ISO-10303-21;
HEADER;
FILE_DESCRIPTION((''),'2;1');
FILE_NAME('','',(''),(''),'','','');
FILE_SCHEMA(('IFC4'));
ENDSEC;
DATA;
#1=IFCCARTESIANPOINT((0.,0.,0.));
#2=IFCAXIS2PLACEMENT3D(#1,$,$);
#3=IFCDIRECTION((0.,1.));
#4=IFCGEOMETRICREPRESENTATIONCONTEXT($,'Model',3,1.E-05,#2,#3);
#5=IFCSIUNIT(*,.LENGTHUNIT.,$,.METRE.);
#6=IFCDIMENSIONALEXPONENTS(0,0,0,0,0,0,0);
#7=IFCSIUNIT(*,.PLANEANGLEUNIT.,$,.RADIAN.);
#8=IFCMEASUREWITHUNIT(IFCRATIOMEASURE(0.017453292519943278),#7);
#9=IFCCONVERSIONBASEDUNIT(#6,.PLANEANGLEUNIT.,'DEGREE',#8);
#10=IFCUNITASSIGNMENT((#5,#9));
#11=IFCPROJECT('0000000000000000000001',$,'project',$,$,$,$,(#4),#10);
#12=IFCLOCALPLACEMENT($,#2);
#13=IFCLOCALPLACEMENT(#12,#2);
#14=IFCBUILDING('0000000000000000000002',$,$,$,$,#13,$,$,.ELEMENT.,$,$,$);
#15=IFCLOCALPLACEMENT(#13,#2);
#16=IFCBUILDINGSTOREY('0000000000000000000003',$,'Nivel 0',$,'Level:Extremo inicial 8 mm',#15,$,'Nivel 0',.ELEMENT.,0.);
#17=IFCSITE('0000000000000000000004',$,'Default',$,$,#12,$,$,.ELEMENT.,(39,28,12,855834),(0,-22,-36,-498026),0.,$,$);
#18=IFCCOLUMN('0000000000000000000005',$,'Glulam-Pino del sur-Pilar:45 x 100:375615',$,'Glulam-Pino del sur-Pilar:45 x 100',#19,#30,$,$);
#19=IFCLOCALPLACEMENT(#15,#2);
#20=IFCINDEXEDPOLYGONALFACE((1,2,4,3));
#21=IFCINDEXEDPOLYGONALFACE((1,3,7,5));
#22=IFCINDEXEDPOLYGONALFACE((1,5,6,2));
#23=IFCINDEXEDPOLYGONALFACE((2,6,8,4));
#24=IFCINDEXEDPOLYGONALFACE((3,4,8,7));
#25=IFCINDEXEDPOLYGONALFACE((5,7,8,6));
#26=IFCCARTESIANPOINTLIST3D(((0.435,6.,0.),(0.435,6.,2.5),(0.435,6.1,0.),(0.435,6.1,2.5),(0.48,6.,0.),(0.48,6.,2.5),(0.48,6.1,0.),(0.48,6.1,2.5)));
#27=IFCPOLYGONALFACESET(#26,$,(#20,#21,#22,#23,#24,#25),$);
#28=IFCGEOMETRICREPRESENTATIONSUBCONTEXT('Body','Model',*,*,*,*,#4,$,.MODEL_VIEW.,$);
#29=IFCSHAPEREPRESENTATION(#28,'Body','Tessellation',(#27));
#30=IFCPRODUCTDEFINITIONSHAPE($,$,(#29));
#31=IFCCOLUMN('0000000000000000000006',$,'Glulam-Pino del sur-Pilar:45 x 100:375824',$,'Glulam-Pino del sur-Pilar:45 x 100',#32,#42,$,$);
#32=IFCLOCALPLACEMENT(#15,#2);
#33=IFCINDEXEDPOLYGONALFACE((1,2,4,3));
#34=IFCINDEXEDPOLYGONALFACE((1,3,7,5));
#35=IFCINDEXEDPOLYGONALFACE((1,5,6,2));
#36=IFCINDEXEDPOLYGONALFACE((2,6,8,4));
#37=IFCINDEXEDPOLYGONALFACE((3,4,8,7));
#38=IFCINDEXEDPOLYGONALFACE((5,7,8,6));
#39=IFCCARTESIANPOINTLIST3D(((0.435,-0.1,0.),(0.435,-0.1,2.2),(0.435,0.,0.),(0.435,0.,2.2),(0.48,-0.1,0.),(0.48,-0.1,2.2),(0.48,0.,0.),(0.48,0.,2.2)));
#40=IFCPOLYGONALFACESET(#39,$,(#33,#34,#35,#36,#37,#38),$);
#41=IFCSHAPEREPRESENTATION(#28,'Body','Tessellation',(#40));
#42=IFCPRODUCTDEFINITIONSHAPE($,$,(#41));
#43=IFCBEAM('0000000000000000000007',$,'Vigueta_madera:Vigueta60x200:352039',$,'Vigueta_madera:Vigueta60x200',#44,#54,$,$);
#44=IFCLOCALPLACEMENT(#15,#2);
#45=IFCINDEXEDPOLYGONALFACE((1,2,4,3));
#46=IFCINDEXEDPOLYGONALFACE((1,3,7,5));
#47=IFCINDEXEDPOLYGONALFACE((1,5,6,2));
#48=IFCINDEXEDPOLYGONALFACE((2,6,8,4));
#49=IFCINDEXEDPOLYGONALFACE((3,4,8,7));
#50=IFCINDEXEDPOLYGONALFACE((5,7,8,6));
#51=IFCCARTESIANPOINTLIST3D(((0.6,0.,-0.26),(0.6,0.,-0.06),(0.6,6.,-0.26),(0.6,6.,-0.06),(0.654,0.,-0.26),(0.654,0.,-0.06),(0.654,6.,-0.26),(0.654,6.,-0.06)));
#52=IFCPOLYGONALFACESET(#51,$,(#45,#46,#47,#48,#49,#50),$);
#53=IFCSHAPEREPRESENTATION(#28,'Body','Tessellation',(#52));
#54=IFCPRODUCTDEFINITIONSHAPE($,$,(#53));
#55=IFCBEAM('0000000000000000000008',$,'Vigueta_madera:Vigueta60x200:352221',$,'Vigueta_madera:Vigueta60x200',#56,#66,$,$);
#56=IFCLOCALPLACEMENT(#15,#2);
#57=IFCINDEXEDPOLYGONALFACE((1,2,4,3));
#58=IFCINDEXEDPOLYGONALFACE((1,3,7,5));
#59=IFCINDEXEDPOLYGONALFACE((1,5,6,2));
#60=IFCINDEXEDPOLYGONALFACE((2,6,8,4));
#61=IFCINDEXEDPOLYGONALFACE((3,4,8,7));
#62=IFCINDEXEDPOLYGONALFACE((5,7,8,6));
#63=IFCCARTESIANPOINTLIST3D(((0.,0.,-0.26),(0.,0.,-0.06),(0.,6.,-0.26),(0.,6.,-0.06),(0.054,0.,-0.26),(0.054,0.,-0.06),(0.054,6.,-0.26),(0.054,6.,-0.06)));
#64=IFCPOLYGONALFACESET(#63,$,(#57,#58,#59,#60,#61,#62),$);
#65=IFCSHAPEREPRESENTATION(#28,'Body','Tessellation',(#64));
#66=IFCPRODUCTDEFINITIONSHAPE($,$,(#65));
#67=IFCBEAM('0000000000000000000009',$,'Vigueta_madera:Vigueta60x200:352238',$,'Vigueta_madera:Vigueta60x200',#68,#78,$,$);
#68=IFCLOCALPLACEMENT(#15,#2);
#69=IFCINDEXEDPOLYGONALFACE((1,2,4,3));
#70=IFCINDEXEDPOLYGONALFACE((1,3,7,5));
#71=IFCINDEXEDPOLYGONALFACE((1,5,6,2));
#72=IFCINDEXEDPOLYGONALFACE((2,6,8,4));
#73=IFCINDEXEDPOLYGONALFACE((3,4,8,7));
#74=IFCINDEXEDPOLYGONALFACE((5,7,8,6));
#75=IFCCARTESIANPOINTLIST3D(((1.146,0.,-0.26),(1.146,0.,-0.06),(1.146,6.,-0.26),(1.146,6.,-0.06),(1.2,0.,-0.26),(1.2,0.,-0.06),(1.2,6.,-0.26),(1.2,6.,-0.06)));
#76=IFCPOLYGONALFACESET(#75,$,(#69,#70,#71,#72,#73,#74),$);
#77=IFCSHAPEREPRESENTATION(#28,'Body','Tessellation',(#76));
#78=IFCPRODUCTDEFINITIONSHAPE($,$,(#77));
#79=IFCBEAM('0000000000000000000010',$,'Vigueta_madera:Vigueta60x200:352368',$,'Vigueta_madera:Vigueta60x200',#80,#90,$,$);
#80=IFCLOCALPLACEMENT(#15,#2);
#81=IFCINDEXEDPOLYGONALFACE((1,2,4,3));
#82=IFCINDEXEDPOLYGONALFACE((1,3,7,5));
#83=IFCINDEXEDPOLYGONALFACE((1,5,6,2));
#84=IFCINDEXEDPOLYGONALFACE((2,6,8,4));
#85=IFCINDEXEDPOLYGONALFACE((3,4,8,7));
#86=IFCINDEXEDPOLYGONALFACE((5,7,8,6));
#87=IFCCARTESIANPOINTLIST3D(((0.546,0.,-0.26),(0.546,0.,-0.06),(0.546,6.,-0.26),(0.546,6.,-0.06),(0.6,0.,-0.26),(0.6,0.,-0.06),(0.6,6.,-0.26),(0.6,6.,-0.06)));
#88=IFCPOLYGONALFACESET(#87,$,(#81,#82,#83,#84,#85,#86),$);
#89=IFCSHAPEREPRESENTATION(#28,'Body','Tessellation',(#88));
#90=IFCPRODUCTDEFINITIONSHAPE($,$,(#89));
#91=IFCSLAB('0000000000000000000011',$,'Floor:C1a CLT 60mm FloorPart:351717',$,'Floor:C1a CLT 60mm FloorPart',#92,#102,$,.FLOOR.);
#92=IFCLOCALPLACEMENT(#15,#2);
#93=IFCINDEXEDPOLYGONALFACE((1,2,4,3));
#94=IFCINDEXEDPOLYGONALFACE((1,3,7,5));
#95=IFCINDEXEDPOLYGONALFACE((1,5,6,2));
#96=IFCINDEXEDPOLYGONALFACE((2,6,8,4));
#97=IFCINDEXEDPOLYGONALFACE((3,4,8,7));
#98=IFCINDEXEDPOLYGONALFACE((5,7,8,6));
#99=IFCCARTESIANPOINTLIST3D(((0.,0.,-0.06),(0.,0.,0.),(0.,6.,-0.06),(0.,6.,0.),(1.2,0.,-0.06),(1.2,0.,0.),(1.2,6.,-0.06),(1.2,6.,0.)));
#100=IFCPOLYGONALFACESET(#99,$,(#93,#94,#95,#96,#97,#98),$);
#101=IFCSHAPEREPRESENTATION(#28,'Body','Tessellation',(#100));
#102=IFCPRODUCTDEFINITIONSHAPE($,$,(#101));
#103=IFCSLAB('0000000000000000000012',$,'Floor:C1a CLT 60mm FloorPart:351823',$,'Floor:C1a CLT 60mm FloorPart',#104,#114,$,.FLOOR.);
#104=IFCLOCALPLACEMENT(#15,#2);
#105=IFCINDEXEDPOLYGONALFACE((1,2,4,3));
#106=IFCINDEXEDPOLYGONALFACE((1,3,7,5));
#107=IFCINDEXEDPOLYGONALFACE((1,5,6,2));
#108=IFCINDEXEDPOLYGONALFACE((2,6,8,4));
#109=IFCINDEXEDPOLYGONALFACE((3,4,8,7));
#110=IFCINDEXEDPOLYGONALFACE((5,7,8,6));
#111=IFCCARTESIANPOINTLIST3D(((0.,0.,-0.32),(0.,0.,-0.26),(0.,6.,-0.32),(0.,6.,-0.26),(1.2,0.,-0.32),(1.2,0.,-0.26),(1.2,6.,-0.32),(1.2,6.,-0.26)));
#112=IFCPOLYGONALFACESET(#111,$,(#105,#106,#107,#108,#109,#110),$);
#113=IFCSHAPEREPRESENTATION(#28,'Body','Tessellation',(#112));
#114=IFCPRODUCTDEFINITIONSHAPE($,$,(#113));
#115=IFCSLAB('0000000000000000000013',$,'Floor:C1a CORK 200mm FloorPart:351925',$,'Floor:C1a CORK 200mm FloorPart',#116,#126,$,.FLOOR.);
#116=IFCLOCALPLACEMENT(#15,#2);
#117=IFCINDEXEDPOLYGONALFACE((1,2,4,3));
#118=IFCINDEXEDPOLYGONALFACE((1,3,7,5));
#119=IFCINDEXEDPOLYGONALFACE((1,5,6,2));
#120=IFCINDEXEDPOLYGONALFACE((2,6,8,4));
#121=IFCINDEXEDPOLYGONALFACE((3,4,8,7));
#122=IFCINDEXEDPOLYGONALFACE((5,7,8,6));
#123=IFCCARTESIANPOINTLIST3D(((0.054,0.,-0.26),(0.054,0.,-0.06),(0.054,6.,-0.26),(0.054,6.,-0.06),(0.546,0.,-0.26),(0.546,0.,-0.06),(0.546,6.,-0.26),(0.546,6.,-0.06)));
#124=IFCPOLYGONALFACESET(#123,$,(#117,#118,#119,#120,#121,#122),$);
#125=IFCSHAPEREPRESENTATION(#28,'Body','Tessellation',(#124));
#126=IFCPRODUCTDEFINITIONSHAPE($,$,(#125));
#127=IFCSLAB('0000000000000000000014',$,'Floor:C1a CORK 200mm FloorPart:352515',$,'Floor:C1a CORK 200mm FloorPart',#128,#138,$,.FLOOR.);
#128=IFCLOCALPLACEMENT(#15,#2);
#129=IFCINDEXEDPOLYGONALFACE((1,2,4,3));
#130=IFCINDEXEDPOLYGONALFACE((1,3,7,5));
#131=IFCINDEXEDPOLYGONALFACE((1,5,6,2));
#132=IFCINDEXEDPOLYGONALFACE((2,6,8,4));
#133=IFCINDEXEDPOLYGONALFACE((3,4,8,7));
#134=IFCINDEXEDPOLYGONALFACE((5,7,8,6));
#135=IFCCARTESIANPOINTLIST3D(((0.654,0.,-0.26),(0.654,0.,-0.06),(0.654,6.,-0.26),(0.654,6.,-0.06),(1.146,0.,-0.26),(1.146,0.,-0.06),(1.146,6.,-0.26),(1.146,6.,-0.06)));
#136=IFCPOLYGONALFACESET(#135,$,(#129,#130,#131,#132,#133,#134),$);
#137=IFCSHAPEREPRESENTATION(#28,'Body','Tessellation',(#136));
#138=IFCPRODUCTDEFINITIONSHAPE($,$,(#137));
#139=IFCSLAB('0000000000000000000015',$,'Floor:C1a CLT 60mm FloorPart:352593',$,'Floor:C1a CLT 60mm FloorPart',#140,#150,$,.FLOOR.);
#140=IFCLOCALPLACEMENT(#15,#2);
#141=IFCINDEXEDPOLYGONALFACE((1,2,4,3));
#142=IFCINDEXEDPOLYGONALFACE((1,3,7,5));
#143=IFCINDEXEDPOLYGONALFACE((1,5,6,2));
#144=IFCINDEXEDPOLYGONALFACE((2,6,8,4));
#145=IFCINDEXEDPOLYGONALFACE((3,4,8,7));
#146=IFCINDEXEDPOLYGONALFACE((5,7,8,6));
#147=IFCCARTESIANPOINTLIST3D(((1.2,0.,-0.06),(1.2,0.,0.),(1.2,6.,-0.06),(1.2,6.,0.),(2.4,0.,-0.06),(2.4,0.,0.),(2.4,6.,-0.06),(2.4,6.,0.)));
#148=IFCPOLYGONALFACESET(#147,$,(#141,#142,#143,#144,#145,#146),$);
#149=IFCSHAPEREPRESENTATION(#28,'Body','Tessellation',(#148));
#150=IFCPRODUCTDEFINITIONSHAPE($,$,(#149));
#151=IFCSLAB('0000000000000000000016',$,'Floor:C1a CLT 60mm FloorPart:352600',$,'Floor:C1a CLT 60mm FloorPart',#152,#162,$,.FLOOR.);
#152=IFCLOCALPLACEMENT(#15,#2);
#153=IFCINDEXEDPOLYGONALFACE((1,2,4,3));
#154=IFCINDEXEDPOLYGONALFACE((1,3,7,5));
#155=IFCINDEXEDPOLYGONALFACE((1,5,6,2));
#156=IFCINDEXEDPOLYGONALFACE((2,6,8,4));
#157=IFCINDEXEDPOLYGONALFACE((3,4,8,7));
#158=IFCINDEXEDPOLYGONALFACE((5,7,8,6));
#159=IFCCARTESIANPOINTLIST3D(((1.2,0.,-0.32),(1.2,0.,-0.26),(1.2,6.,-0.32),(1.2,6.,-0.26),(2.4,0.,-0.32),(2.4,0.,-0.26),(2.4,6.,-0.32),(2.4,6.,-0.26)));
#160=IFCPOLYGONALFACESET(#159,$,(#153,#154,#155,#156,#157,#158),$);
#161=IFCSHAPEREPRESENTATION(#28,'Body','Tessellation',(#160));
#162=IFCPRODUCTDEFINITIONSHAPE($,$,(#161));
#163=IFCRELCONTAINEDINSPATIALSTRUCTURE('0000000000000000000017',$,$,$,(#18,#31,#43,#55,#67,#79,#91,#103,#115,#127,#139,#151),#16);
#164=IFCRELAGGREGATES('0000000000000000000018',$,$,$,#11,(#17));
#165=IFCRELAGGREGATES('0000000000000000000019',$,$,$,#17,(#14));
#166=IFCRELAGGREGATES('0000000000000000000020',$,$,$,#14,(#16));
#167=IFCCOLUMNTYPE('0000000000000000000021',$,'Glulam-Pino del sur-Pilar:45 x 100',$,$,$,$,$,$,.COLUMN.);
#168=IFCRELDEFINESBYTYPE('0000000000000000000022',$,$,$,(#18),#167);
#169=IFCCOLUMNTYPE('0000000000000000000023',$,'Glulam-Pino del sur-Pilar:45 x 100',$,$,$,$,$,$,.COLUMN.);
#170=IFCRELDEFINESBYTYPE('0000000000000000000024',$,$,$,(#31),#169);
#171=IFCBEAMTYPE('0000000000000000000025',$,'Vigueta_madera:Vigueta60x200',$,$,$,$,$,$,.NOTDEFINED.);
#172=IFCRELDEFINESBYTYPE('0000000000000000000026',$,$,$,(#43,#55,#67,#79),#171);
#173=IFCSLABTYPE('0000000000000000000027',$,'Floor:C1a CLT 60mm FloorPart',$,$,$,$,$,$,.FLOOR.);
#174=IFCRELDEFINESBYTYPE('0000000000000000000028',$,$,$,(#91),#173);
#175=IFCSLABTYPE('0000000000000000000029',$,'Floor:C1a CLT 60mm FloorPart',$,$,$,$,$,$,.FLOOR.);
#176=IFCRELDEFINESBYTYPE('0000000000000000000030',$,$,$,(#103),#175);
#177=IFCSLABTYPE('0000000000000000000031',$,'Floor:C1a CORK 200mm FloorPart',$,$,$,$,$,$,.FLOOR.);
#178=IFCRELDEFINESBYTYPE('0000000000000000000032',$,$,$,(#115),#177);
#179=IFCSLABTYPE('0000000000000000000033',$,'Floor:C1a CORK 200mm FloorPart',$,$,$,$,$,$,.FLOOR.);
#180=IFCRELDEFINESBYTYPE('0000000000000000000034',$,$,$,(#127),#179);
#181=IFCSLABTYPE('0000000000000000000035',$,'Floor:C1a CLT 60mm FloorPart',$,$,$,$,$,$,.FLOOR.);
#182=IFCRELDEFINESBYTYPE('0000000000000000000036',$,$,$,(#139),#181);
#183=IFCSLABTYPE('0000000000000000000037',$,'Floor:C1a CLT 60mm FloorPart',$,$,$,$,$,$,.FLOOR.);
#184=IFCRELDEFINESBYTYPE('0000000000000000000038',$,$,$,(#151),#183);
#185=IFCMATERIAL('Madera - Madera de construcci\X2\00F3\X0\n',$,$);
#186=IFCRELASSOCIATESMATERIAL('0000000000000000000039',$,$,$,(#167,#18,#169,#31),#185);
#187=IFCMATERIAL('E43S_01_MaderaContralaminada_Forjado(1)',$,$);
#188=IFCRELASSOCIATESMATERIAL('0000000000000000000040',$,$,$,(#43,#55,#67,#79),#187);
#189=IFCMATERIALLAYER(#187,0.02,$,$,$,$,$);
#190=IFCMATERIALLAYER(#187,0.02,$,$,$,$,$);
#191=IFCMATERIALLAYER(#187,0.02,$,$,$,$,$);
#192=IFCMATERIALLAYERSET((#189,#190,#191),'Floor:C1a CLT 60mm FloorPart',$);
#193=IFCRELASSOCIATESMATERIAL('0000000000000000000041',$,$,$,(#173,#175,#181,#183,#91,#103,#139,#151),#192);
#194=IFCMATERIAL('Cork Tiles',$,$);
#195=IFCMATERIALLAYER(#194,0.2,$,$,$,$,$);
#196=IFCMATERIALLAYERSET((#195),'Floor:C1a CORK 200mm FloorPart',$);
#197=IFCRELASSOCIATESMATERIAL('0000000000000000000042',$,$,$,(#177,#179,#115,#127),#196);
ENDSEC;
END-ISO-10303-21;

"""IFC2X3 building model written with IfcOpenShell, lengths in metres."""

from ifc_helpers import new_model, entity, si_unit, converted_unit, direction, frame, frame_2d, origin, origin_2d_with_axis, place, context, subcontext, project, spatial, rectangle, extrude, source, transform, mapped, material, layer, layer_set, layer_usage, type_object, type_shapes, element, save


model = new_model("IFC2X3")

# Units and contexts
model_context = context("Model", 3, precision=1e-05, world=origin(), true_north=direction((0.0, 1.0)))
body_context = subcontext(model_context, "Body", "Model", "MODEL_VIEW")
ifc_project = project(units=[si_unit("LENGTHUNIT", "METRE"), converted_unit("PLANEANGLEUNIT", "DEGREE", entity("IfcRatioMeasure", 0.017453292519943278), si_unit("PLANEANGLEUNIT", "RADIAN"), dimensions=[0, 0, 0, 0, 0, 0, 0])], contexts=[model_context])

# Site, building, storey
site_placement = place(None, origin())
site = spatial("IfcSite", under=ifc_project, at=site_placement, Name="Default", CompositionType="ELEMENT", RefLatitude=(39, 28, 12, 855834), RefLongitude=(0, -22, -36, -498026), RefElevation=0.0)
building_placement = place(site_placement, origin())
building = spatial("IfcBuilding", under=site, at=building_placement, CompositionType="ELEMENT")
storey_placement = place(building_placement, origin())
storey = spatial("IfcBuildingStorey", under=building, at=storey_placement, Name="Nivel 0", ObjectType="Level:Extremo inicial 8 mm", LongName="Nivel 0", CompositionType="ELEMENT", Elevation=0.0)

# Columns
ifc_material_1 = material(Name="Madera - Madera de construcción")
column_type_1 = type_object("IfcColumnType", Name="Glulam-Pino del sur-Pilar:45 x 100", PredefinedType="COLUMN", material=ifc_material_1)
shared_shape_1 = source(origin(), body_context, "Body", "SweptSolid", [
    extrude(rectangle(XDim=0.1, YDim=0.045, at=origin_2d_with_axis()), frame((0.0, 0.0, 0.0), z_axis=(0.0, 0.0, 1.0), x_axis=(0.0, -1.0, 0.0)), (0.0, 0.0, 1.0), 2.5),
])
type_shapes(column_type_1, [shared_shape_1])
column_1_placement = place(storey_placement, frame((0.4575, 6.05, 0.0)))
element("IfcColumn", 1, at=column_1_placement, inside=storey, type_object=column_type_1, material=ifc_material_1, Name="Glulam-Pino del sur-Pilar:45 x 100:375615", ObjectType="Glulam-Pino del sur-Pilar:45 x 100", context=body_context, shape_type="MappedRepresentation", body=[
    mapped(shared_shape_1, transform((0.0, 0.0, 0.0), scale=1.0)),
])
column_type_2 = type_object("IfcColumnType", Name="Glulam-Pino del sur-Pilar:45 x 100", PredefinedType="COLUMN", material=ifc_material_1)
shared_shape_2 = source(origin(), body_context, "Body", "SweptSolid", [
    extrude(rectangle(XDim=0.1, YDim=0.045, at=origin_2d_with_axis()), frame((0.0, 0.0, 0.0), z_axis=(0.0, 0.0, 1.0), x_axis=(0.0, -1.0, 0.0)), (0.0, 0.0, 1.0), 2.2),
])
type_shapes(column_type_2, [shared_shape_2])
column_2_placement = place(storey_placement, frame((0.4575, -0.05, 0.0), z_axis=(0.0, 0.0, 1.0), x_axis=(-1.0, 0.0, 0.0)))
element("IfcColumn", 2, at=column_2_placement, inside=storey, type_object=column_type_2, material=ifc_material_1, Name="Glulam-Pino del sur-Pilar:45 x 100:375824", ObjectType="Glulam-Pino del sur-Pilar:45 x 100", context=body_context, shape_type="MappedRepresentation", body=[
    mapped(shared_shape_2, transform((0.0, 0.0, 0.0), scale=1.0)),
])

# Beams
ifc_material_2 = material(Name="E43S_01_MaderaContralaminada_Forjado(1)")
beam_type = type_object("IfcBeamType", Name="Vigueta_madera:Vigueta60x200", PredefinedType="NOTDEFINED")
beam_1_placement = place(storey_placement, frame((0.627, 0.0, -0.06), z_axis=(0.0, 0.0, 1.0), x_axis=(0.0, 1.0, 0.0)))
element("IfcBeam", 3, at=beam_1_placement, inside=storey, type_object=beam_type, material=ifc_material_2, Name="Vigueta_madera:Vigueta60x200:352039", ObjectType="Vigueta_madera:Vigueta60x200", context=body_context, shape_type="SweptSolid", body=[
    extrude(rectangle(XDim=0.2, YDim=0.054, at=frame_2d((0.0, 0.0), x_axis=(1.0, 0.0))), frame((0.0, 0.0, -0.1), z_axis=(1.0, 0.0, 0.0), x_axis=(0.0, 0.0, -1.0)), (0.0, 0.0, 1.0), 6.0),
])
beam_2_placement = place(storey_placement, frame((0.027, 0.0, -0.06), z_axis=(0.0, 0.0, 1.0), x_axis=(0.0, 1.0, 0.0)))
element("IfcBeam", 4, at=beam_2_placement, inside=storey, type_object=beam_type, material=ifc_material_2, Name="Vigueta_madera:Vigueta60x200:352221", ObjectType="Vigueta_madera:Vigueta60x200", context=body_context, shape_type="SweptSolid", body=[
    extrude(rectangle(XDim=0.2, YDim=0.054, at=origin_2d_with_axis()), frame((0.0, 0.0, -0.1), z_axis=(1.0, 0.0, 0.0), x_axis=(0.0, 0.0, -1.0)), (0.0, 0.0, 1.0), 6.0),
])
beam_3_placement = place(storey_placement, frame((1.173, 0.0, -0.06), z_axis=(0.0, 0.0, 1.0), x_axis=(0.0, 1.0, 0.0)))
element("IfcBeam", 5, at=beam_3_placement, inside=storey, type_object=beam_type, material=ifc_material_2, Name="Vigueta_madera:Vigueta60x200:352238", ObjectType="Vigueta_madera:Vigueta60x200", context=body_context, shape_type="SweptSolid", body=[
    extrude(rectangle(XDim=0.2, YDim=0.054, at=origin_2d_with_axis()), frame((0.0, 0.0, -0.1), z_axis=(1.0, 0.0, 0.0), x_axis=(0.0, 0.0, -1.0)), (0.0, 0.0, 1.0), 6.0),
])
beam_4_placement = place(storey_placement, frame((0.573, 0.0, -0.06), z_axis=(0.0, 0.0, 1.0), x_axis=(0.0, 1.0, 0.0)))
element("IfcBeam", 6, at=beam_4_placement, inside=storey, type_object=beam_type, material=ifc_material_2, Name="Vigueta_madera:Vigueta60x200:352368", ObjectType="Vigueta_madera:Vigueta60x200", context=body_context, shape_type="SweptSolid", body=[
    extrude(rectangle(XDim=0.2, YDim=0.054, at=frame_2d((0.0, 0.0), x_axis=(1.0, 0.0))), frame((0.0, 0.0, -0.1), z_axis=(1.0, 0.0, 0.0), x_axis=(0.0, 0.0, -1.0)), (0.0, 0.0, 1.0), 6.0),
])

# Slabs
ifc_layer_1 = layer(ifc_material_2, 0.02)
ifc_layer_2 = layer(ifc_material_2, 0.02)
ifc_layer_3 = layer(ifc_material_2, 0.02)
ifc_layer_set_1 = layer_set([ifc_layer_1, ifc_layer_2, ifc_layer_3], Name="Floor:C1a CLT 60mm FloorPart")
ifc_layer_usage_1 = layer_usage(ifc_layer_set_1, "AXIS3", "POSITIVE", 0.0)
slab_type_1 = type_object("IfcSlabType", Name="Floor:C1a CLT 60mm FloorPart", PredefinedType="FLOOR", material=ifc_layer_set_1)
slab_1_placement = place(storey_placement, origin())
element("IfcSlab", 7, at=slab_1_placement, inside=storey, type_object=slab_type_1, material=ifc_layer_usage_1, Name="Floor:C1a CLT 60mm FloorPart:351717", ObjectType="Floor:C1a CLT 60mm FloorPart", PredefinedType="FLOOR", context=body_context, shape_type="SweptSolid", body=[
    extrude(rectangle(XDim=6.0, YDim=1.2, at=frame_2d((0.0, 0.0), x_axis=(1.0, 0.0))), frame((0.6, 3.0, 0.0), z_axis=(0.0, 0.0, -1.0), x_axis=(0.0, 1.0, 0.0)), (0.0, 0.0, 1.0), 0.06),
])
ifc_layer_usage_2 = layer_usage(ifc_layer_set_1, "AXIS3", "POSITIVE", 0.0)
slab_type_2 = type_object("IfcSlabType", Name="Floor:C1a CLT 60mm FloorPart", PredefinedType="FLOOR", material=ifc_layer_set_1)
slab_2_placement = place(storey_placement, origin())
element("IfcSlab", 8, at=slab_2_placement, inside=storey, type_object=slab_type_2, material=ifc_layer_usage_2, Name="Floor:C1a CLT 60mm FloorPart:351823", ObjectType="Floor:C1a CLT 60mm FloorPart", PredefinedType="FLOOR", context=body_context, shape_type="SweptSolid", body=[
    extrude(rectangle(XDim=6.0, YDim=1.2, at=frame_2d((0.0, 0.0), x_axis=(1.0, 0.0))), frame((0.6, 3.0, -0.26), z_axis=(0.0, 0.0, -1.0), x_axis=(0.0, 1.0, 0.0)), (0.0, 0.0, 1.0), 0.06),
])
ifc_material_3 = material(Name="Cork Tiles")
ifc_layer_4 = layer(ifc_material_3, 0.2)
ifc_layer_set_2 = layer_set([ifc_layer_4], Name="Floor:C1a CORK 200mm FloorPart")
ifc_layer_usage_3 = layer_usage(ifc_layer_set_2, "AXIS3", "POSITIVE", 0.0)
slab_type_3 = type_object("IfcSlabType", Name="Floor:C1a CORK 200mm FloorPart", PredefinedType="FLOOR", material=ifc_layer_set_2)
slab_3_placement = place(storey_placement, origin())
element("IfcSlab", 9, at=slab_3_placement, inside=storey, type_object=slab_type_3, material=ifc_layer_usage_3, Name="Floor:C1a CORK 200mm FloorPart:351925", ObjectType="Floor:C1a CORK 200mm FloorPart", PredefinedType="FLOOR", context=body_context, shape_type="SweptSolid", body=[
    extrude(rectangle(XDim=6.0, YDim=0.492, at=frame_2d((0.0, 0.0), x_axis=(1.0, 0.0))), frame((0.3, 3.0, -0.06), z_axis=(0.0, 0.0, -1.0), x_axis=(0.0, 1.0, 0.0)), (0.0, 0.0, 1.0), 0.2),
])
ifc_layer_usage_4 = layer_usage(ifc_layer_set_2, "AXIS3", "POSITIVE", 0.0)
slab_type_4 = type_object("IfcSlabType", Name="Floor:C1a CORK 200mm FloorPart", PredefinedType="FLOOR", material=ifc_layer_set_2)
slab_4_placement = place(storey_placement, origin())
element("IfcSlab", 10, at=slab_4_placement, inside=storey, type_object=slab_type_4, material=ifc_layer_usage_4, Name="Floor:C1a CORK 200mm FloorPart:352515", ObjectType="Floor:C1a CORK 200mm FloorPart", PredefinedType="FLOOR", context=body_context, shape_type="SweptSolid", body=[
    extrude(rectangle(XDim=6.0, YDim=0.492, at=frame_2d((0.0, 0.0), x_axis=(1.0, 0.0))), frame((0.9, 3.0, -0.06), z_axis=(0.0, 0.0, -1.0), x_axis=(0.0, 1.0, 0.0)), (0.0, 0.0, 1.0), 0.2),
])
ifc_layer_usage_5 = layer_usage(ifc_layer_set_1, "AXIS3", "POSITIVE", 0.0)
slab_type_5 = type_object("IfcSlabType", Name="Floor:C1a CLT 60mm FloorPart", PredefinedType="FLOOR", material=ifc_layer_set_1)
slab_5_placement = place(storey_placement, origin())
element("IfcSlab", 11, at=slab_5_placement, inside=storey, type_object=slab_type_5, material=ifc_layer_usage_5, Name="Floor:C1a CLT 60mm FloorPart:352593", ObjectType="Floor:C1a CLT 60mm FloorPart", PredefinedType="FLOOR", context=body_context, shape_type="SweptSolid", body=[
    extrude(rectangle(XDim=6.0, YDim=1.2, at=frame_2d((0.0, 0.0), x_axis=(1.0, 0.0))), frame((1.8, 3.0, 0.0), z_axis=(0.0, 0.0, -1.0), x_axis=(0.0, 1.0, 0.0)), (0.0, 0.0, 1.0), 0.06),
])
ifc_layer_usage_6 = layer_usage(ifc_layer_set_1, "AXIS3", "POSITIVE", 0.0)
slab_type_6 = type_object("IfcSlabType", Name="Floor:C1a CLT 60mm FloorPart", PredefinedType="FLOOR", material=ifc_layer_set_1)
slab_6_placement = place(storey_placement, origin())
element("IfcSlab", 12, at=slab_6_placement, inside=storey, type_object=slab_type_6, material=ifc_layer_usage_6, Name="Floor:C1a CLT 60mm FloorPart:352600", ObjectType="Floor:C1a CLT 60mm FloorPart", PredefinedType="FLOOR", context=body_context, shape_type="SweptSolid", body=[
    extrude(rectangle(XDim=6.0, YDim=1.2, at=frame_2d((0.0, 0.0), x_axis=(1.0, 0.0))), frame((1.8, 3.0, -0.26), z_axis=(0.0, 0.0, -1.0), x_axis=(0.0, 1.0, 0.0)), (0.0, 0.0, 1.0), 0.06),
])

save(model, "model.ifc")
